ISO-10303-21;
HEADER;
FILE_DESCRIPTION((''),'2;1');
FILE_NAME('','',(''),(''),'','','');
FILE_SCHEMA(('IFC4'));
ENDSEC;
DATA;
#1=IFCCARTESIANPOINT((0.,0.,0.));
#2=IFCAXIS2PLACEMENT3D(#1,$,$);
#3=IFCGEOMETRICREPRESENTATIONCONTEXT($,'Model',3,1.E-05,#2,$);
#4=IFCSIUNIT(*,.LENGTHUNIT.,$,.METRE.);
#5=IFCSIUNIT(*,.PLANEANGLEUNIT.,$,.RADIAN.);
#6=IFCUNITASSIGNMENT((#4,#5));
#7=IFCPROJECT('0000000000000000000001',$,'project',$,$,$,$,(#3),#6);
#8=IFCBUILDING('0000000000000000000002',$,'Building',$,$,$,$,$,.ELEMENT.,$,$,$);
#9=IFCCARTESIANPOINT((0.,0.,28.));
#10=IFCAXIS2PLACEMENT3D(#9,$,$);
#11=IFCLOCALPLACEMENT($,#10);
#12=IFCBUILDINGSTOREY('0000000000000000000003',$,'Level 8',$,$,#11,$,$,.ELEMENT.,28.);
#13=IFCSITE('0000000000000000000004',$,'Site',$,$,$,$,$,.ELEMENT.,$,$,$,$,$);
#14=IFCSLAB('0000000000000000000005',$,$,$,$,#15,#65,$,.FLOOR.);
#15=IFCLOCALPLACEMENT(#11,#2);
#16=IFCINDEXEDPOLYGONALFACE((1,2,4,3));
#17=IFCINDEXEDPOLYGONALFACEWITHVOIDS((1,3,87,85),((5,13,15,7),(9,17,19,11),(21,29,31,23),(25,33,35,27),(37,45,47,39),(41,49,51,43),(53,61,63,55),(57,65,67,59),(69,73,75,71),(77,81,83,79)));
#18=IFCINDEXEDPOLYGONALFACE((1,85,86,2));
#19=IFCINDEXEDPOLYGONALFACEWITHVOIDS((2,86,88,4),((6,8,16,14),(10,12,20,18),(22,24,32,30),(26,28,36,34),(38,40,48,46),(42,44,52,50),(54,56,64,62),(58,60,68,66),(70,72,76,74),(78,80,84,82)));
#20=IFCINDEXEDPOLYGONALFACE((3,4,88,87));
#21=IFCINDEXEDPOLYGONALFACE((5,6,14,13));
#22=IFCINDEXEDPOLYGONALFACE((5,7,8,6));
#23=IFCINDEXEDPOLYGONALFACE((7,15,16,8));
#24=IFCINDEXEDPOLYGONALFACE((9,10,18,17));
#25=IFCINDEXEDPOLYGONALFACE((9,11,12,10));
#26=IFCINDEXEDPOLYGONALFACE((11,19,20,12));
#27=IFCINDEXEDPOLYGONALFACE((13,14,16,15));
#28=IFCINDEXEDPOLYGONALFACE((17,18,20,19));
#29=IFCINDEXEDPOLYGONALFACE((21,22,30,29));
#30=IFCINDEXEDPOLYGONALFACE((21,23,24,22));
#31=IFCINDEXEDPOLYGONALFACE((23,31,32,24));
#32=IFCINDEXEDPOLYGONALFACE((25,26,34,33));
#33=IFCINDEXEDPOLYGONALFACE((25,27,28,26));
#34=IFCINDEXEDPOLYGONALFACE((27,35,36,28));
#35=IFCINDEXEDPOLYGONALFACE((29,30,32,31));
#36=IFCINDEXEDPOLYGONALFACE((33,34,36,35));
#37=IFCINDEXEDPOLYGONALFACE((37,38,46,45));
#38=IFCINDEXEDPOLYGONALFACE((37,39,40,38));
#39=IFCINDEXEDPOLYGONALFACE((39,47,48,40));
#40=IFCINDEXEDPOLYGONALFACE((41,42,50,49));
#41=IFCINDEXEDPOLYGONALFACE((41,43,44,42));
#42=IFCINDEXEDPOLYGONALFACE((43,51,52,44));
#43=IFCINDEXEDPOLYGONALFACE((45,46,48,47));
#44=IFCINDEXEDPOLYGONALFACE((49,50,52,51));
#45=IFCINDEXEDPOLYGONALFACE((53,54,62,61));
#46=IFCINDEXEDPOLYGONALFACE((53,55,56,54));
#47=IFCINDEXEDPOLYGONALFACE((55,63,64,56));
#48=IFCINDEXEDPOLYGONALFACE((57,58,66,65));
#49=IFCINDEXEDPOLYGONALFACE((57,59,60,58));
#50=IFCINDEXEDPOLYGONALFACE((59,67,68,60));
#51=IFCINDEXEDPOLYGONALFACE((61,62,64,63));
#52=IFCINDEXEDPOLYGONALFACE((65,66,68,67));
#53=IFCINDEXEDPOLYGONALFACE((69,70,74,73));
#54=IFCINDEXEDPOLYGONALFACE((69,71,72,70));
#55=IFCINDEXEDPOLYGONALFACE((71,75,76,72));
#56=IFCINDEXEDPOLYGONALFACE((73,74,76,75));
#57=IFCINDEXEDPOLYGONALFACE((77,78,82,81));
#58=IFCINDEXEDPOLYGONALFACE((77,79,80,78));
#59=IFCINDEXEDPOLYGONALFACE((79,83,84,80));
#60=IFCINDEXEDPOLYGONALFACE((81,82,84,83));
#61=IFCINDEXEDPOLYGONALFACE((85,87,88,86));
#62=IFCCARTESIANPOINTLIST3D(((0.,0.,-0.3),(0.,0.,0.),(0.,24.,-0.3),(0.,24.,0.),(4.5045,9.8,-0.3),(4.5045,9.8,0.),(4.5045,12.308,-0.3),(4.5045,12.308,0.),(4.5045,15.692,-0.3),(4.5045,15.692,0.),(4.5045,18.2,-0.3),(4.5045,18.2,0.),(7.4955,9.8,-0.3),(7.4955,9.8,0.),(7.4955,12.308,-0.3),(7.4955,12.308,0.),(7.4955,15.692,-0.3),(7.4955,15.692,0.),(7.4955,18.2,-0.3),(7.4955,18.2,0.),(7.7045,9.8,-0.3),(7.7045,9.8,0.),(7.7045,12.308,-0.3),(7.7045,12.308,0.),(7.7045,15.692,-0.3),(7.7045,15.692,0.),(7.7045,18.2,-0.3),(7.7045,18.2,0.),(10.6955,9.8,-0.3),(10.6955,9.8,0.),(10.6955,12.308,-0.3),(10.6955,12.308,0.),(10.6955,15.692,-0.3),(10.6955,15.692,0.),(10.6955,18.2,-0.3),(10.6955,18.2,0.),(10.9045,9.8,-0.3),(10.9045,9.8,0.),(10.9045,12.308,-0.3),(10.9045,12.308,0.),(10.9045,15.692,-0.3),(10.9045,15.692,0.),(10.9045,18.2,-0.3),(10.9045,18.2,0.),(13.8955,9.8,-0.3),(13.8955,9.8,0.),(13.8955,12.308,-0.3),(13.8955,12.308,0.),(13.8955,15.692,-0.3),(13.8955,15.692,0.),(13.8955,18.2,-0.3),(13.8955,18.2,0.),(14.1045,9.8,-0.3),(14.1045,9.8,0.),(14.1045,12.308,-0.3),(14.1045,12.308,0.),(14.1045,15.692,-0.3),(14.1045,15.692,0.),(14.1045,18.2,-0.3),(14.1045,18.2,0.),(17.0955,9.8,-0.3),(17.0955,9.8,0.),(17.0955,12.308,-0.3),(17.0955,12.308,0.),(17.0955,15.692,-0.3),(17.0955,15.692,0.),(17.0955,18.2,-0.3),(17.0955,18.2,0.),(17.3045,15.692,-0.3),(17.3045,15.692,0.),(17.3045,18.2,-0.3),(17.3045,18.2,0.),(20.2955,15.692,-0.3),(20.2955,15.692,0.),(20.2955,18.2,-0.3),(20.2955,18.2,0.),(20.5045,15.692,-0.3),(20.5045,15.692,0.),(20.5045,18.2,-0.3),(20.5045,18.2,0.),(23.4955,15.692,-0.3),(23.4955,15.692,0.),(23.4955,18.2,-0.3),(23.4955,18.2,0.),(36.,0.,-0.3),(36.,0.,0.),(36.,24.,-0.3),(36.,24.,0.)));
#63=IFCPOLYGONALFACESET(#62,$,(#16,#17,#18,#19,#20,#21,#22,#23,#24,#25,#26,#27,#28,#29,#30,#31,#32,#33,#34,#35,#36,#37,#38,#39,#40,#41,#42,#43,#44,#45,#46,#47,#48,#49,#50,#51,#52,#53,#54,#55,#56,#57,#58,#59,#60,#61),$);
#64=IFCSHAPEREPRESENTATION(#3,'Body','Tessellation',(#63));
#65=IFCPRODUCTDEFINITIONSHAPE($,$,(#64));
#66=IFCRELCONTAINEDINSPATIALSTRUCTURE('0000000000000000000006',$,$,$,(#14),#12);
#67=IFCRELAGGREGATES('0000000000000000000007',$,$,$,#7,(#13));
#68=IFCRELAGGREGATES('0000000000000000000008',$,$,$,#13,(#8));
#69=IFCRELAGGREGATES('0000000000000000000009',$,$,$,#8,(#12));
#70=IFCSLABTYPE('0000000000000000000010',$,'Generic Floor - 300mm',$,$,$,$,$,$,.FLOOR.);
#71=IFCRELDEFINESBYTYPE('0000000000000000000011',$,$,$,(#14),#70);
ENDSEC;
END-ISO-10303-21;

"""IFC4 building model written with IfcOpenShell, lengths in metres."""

from ifc_helpers import new_model, si_unit, frame, origin, place, context, project, spatial, polyline, outline, extrude, type_object, element, save


model = new_model("IFC4")

# Units and contexts
model_context = context("Model", 3, precision=1e-05, world=origin())
ifc_project = project(units=[si_unit("LENGTHUNIT", "METRE"), si_unit("PLANEANGLEUNIT", "RADIAN")], contexts=[model_context])

# Site, building, storey
site = spatial("IfcSite", under=ifc_project, Name="Site", CompositionType="ELEMENT")
building = spatial("IfcBuilding", under=site, Name="Building", CompositionType="ELEMENT")
storey_placement = place(None, frame((0.0, 0.0, 28.0)))
storey = spatial("IfcBuildingStorey", under=building, at=storey_placement, Name="Level 8", CompositionType="ELEMENT", Elevation=28.0)

# Slab, openings
slab_type = type_object("IfcSlabType", Name="Generic Floor - 300mm", PredefinedType="FLOOR")
slab_placement = place(None, frame((0.0, 0.0, 28.0)))
slab = element("IfcSlab", 1, at=slab_placement, inside=storey, type_object=slab_type, PredefinedType="FLOOR", context=model_context, shape_type="SweptSolid", body=[
    extrude(outline(polyline([(0.0, 0.0), (36.0, 0.0), (36.0, 24.0), (0.0, 24.0), (0.0, 0.0)])), origin(), (0.0, 0.0, -1.0), 0.3),
])
opening_1_placement = place(None, frame((0.0, 0.0, 28.001)))
element("IfcOpeningElement", 2, at=opening_1_placement, cuts=slab, PredefinedType="OPENING", context=model_context, shape_type="SweptSolid", body=[
    extrude(outline(polyline([(4.5045, 9.8), (7.4955, 9.8), (7.4955, 12.308), (4.5045, 12.308), (4.5045, 9.8)])), origin(), (0.0, 0.0, -1.0), 0.302),
])
opening_2_placement = place(None, frame((0.0, 0.0, 28.001)))
element("IfcOpeningElement", 3, at=opening_2_placement, cuts=slab, PredefinedType="OPENING", context=model_context, shape_type="SweptSolid", body=[
    extrude(outline(polyline([(7.7045, 9.8), (10.6955, 9.8), (10.6955, 12.308), (7.7045, 12.308), (7.7045, 9.8)])), origin(), (0.0, 0.0, -1.0), 0.302),
])
opening_3_placement = place(None, frame((0.0, 0.0, 28.001)))
element("IfcOpeningElement", 4, at=opening_3_placement, cuts=slab, PredefinedType="OPENING", context=model_context, shape_type="SweptSolid", body=[
    extrude(outline(polyline([(10.9045, 9.8), (13.8955, 9.8), (13.8955, 12.308), (10.9045, 12.308), (10.9045, 9.8)])), origin(), (0.0, 0.0, -1.0), 0.302),
])
opening_4_placement = place(None, frame((0.0, 0.0, 28.001)))
element("IfcOpeningElement", 5, at=opening_4_placement, cuts=slab, PredefinedType="OPENING", context=model_context, shape_type="SweptSolid", body=[
    extrude(outline(polyline([(14.1045, 9.8), (17.0955, 9.8), (17.0955, 12.308), (14.1045, 12.308), (14.1045, 9.8)])), origin(), (0.0, 0.0, -1.0), 0.302),
])
opening_5_placement = place(None, frame((0.0, 0.0, 28.001)))
element("IfcOpeningElement", 6, at=opening_5_placement, cuts=slab, PredefinedType="OPENING", context=model_context, shape_type="SweptSolid", body=[
    extrude(outline(polyline([(7.4955, 18.2), (4.5045, 18.2), (4.5045, 15.692), (7.4955, 15.692), (7.4955, 18.2)])), origin(), (0.0, 0.0, -1.0), 0.302),
])
opening_6_placement = place(None, frame((0.0, 0.0, 28.001)))
element("IfcOpeningElement", 7, at=opening_6_placement, cuts=slab, PredefinedType="OPENING", context=model_context, shape_type="SweptSolid", body=[
    extrude(outline(polyline([(10.6955, 18.2), (7.7045, 18.2), (7.7045, 15.692), (10.6955, 15.692), (10.6955, 18.2)])), origin(), (0.0, 0.0, -1.0), 0.302),
])
opening_7_placement = place(None, frame((0.0, 0.0, 28.001)))
element("IfcOpeningElement", 8, at=opening_7_placement, cuts=slab, PredefinedType="OPENING", context=model_context, shape_type="SweptSolid", body=[
    extrude(outline(polyline([(13.8955, 18.2), (10.9045, 18.2), (10.9045, 15.692), (13.8955, 15.692), (13.8955, 18.2)])), origin(), (0.0, 0.0, -1.0), 0.302),
])
opening_8_placement = place(None, frame((0.0, 0.0, 28.001)))
element("IfcOpeningElement", 9, at=opening_8_placement, cuts=slab, PredefinedType="OPENING", context=model_context, shape_type="SweptSolid", body=[
    extrude(outline(polyline([(17.0955, 18.2), (14.1045, 18.2), (14.1045, 15.692), (17.0955, 15.692), (17.0955, 18.2)])), origin(), (0.0, 0.0, -1.0), 0.302),
])
opening_9_placement = place(None, frame((0.0, 0.0, 28.001)))
element("IfcOpeningElement", 10, at=opening_9_placement, cuts=slab, PredefinedType="OPENING", context=model_context, shape_type="SweptSolid", body=[
    extrude(outline(polyline([(20.2955, 18.2), (17.3045, 18.2), (17.3045, 15.692), (20.2955, 15.692), (20.2955, 18.2)])), origin(), (0.0, 0.0, -1.0), 0.302),
])
opening_10_placement = place(None, frame((0.0, 0.0, 28.001)))
element("IfcOpeningElement", 11, at=opening_10_placement, cuts=slab, PredefinedType="OPENING", context=model_context, shape_type="SweptSolid", body=[
    extrude(outline(polyline([(23.4955, 18.2), (20.5045, 18.2), (20.5045, 15.692), (23.4955, 15.692), (23.4955, 18.2)])), origin(), (0.0, 0.0, -1.0), 0.302),
])

save(model, "model.ifc")
